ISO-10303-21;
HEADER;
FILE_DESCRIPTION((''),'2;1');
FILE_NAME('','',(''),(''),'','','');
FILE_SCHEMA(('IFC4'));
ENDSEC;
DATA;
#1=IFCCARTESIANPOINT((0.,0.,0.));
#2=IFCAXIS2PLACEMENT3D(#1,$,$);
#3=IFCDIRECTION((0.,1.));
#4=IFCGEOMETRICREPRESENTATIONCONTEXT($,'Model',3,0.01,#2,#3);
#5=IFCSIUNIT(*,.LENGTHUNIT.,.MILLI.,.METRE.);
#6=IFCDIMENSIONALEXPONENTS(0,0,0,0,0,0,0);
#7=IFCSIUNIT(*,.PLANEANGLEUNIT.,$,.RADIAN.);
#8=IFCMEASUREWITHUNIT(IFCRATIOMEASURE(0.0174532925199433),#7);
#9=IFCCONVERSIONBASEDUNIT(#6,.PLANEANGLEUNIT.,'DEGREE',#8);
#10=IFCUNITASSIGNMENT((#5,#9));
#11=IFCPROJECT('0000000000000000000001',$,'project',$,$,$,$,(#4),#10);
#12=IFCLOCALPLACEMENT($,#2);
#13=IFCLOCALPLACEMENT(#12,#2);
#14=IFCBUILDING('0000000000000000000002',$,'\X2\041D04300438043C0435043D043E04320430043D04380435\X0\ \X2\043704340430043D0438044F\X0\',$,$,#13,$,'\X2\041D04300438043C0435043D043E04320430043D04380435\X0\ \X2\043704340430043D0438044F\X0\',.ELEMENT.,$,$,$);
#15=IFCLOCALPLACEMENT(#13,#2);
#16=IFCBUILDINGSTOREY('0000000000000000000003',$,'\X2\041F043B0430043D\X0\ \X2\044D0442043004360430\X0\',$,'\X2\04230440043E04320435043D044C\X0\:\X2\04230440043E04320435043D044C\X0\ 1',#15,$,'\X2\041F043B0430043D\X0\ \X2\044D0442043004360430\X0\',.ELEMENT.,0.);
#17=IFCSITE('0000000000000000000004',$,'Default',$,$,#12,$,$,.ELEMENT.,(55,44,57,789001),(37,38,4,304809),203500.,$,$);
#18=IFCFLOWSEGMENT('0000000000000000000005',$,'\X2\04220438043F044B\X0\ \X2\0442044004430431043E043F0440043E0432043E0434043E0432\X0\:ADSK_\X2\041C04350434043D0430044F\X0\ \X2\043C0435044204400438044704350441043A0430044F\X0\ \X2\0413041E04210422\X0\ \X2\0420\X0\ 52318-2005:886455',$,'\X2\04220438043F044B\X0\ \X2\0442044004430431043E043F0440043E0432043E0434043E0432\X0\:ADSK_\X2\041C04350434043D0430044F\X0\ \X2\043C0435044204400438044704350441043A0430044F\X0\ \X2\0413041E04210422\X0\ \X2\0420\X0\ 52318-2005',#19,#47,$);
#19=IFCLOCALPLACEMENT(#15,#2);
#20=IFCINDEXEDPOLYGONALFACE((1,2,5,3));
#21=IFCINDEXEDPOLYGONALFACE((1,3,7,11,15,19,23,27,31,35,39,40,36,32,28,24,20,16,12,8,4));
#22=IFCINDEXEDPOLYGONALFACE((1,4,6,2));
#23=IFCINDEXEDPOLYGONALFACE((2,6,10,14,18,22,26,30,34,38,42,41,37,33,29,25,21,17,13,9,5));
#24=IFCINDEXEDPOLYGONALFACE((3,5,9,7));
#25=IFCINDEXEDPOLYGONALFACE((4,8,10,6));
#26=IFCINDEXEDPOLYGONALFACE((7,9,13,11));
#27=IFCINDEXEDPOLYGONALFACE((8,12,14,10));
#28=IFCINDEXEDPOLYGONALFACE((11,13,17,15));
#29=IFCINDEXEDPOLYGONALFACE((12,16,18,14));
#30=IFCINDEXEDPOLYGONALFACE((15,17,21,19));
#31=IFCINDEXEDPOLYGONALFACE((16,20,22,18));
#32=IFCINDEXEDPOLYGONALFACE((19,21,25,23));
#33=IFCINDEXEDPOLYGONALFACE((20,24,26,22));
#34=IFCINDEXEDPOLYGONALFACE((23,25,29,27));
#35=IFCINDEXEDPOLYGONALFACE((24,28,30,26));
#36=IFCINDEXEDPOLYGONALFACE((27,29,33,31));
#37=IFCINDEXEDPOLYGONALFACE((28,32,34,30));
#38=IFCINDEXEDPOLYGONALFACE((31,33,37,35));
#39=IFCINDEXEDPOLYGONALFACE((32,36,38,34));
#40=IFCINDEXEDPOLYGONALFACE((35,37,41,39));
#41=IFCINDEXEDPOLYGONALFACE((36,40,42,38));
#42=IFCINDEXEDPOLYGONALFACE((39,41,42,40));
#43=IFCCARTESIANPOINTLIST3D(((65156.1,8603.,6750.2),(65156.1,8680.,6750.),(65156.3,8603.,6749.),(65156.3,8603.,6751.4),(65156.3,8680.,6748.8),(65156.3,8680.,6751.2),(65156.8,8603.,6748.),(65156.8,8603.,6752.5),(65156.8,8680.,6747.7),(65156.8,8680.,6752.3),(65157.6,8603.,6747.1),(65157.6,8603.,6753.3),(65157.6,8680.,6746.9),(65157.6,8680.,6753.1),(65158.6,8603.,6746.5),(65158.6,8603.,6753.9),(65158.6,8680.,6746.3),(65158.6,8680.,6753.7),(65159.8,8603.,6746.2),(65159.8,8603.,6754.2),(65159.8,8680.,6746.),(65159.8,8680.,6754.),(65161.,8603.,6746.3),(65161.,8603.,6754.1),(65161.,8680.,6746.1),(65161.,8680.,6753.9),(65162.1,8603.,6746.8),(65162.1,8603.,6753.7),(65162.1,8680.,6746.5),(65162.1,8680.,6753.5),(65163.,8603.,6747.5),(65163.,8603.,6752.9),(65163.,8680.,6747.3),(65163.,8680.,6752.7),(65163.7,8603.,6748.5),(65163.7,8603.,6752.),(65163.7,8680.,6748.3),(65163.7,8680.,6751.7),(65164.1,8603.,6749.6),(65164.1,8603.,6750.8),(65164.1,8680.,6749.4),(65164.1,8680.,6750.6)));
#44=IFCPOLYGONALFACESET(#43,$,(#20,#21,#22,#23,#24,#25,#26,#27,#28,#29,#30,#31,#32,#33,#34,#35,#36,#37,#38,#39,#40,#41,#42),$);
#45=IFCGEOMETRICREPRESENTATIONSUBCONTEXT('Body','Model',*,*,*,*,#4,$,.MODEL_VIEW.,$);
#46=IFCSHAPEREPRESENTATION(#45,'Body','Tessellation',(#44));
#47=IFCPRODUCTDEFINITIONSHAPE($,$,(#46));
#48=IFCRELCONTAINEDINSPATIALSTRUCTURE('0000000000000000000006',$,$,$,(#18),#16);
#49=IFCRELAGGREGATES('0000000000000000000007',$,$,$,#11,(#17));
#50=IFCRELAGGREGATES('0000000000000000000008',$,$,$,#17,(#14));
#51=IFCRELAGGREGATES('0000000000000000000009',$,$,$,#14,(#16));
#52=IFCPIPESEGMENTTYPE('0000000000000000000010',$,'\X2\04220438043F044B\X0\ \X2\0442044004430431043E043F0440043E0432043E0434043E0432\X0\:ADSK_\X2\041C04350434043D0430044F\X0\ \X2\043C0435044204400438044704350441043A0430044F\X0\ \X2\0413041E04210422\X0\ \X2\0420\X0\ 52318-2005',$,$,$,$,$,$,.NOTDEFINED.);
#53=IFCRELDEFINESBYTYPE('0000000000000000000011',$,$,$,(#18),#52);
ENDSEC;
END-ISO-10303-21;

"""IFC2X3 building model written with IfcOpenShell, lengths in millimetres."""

from ifc_helpers import new_model, entity, si_unit, converted_unit, direction, frame, frame_2d, origin, place, context, subcontext, project, spatial, circle, extrude, type_object, element, save


model = new_model("IFC2X3")

# Units and contexts
model_context = context("Model", 3, precision=0.01, world=origin(), true_north=direction((0.0, 1.0)))
body_context = subcontext(model_context, "Body", "Model", "MODEL_VIEW")
ifc_project = project(units=[si_unit("LENGTHUNIT", "METRE", prefix="MILLI"), converted_unit("PLANEANGLEUNIT", "DEGREE", entity("IfcRatioMeasure", 0.0174532925199433), si_unit("PLANEANGLEUNIT", "RADIAN"), dimensions=[0, 0, 0, 0, 0, 0, 0])], contexts=[model_context])

# Site, building, storey
site_placement = place(None, frame((0.0, 0.0, 0.0)))
site = spatial("IfcSite", under=ifc_project, at=site_placement, Name="Default", CompositionType="ELEMENT", RefLatitude=(55, 44, 57, 789001), RefLongitude=(37, 38, 4, 304809), RefElevation=203500.0)
building_placement = place(site_placement, origin())
building = spatial("IfcBuilding", under=site, at=building_placement, Name="Наименование здания", LongName="Наименование здания", CompositionType="ELEMENT")
storey_placement = place(building_placement, origin())
storey = spatial("IfcBuildingStorey", under=building, at=storey_placement, Name="План этажа", ObjectType="Уровень:Уровень 1", LongName="План этажа", CompositionType="ELEMENT", Elevation=0.0)

# Flow segment
pipe_segment_type = type_object("IfcPipeSegmentType", Name="Типы трубопроводов:ADSK_Медная метрическая ГОСТ Р 52318-2005", PredefinedType="NOTDEFINED")
flow_segment_1_placement = place(storey_placement, frame((65154.5, 8603.0, 6744.4)))
element("IfcFlowSegment", 1, at=flow_segment_1_placement, inside=storey, type_object=pipe_segment_type, Name="Типы трубопроводов:ADSK_Медная метрическая ГОСТ Р 52318-2005:886455", ObjectType="Типы трубопроводов:ADSK_Медная метрическая ГОСТ Р 52318-2005", context=body_context, shape_type="SweptSolid", body=[
    extrude(circle(Radius=4.0, at=frame_2d((0.0, 0.0), x_axis=(1.0, 0.0))), frame((5.6, 77.0, 5.6), z_axis=(0.0, -0.999996, 0.002866), x_axis=(-1.0, 0.0, 0.0)), (0.0, 0.0, 1.0), 77.0),
])

save(model, "model.ifc")
